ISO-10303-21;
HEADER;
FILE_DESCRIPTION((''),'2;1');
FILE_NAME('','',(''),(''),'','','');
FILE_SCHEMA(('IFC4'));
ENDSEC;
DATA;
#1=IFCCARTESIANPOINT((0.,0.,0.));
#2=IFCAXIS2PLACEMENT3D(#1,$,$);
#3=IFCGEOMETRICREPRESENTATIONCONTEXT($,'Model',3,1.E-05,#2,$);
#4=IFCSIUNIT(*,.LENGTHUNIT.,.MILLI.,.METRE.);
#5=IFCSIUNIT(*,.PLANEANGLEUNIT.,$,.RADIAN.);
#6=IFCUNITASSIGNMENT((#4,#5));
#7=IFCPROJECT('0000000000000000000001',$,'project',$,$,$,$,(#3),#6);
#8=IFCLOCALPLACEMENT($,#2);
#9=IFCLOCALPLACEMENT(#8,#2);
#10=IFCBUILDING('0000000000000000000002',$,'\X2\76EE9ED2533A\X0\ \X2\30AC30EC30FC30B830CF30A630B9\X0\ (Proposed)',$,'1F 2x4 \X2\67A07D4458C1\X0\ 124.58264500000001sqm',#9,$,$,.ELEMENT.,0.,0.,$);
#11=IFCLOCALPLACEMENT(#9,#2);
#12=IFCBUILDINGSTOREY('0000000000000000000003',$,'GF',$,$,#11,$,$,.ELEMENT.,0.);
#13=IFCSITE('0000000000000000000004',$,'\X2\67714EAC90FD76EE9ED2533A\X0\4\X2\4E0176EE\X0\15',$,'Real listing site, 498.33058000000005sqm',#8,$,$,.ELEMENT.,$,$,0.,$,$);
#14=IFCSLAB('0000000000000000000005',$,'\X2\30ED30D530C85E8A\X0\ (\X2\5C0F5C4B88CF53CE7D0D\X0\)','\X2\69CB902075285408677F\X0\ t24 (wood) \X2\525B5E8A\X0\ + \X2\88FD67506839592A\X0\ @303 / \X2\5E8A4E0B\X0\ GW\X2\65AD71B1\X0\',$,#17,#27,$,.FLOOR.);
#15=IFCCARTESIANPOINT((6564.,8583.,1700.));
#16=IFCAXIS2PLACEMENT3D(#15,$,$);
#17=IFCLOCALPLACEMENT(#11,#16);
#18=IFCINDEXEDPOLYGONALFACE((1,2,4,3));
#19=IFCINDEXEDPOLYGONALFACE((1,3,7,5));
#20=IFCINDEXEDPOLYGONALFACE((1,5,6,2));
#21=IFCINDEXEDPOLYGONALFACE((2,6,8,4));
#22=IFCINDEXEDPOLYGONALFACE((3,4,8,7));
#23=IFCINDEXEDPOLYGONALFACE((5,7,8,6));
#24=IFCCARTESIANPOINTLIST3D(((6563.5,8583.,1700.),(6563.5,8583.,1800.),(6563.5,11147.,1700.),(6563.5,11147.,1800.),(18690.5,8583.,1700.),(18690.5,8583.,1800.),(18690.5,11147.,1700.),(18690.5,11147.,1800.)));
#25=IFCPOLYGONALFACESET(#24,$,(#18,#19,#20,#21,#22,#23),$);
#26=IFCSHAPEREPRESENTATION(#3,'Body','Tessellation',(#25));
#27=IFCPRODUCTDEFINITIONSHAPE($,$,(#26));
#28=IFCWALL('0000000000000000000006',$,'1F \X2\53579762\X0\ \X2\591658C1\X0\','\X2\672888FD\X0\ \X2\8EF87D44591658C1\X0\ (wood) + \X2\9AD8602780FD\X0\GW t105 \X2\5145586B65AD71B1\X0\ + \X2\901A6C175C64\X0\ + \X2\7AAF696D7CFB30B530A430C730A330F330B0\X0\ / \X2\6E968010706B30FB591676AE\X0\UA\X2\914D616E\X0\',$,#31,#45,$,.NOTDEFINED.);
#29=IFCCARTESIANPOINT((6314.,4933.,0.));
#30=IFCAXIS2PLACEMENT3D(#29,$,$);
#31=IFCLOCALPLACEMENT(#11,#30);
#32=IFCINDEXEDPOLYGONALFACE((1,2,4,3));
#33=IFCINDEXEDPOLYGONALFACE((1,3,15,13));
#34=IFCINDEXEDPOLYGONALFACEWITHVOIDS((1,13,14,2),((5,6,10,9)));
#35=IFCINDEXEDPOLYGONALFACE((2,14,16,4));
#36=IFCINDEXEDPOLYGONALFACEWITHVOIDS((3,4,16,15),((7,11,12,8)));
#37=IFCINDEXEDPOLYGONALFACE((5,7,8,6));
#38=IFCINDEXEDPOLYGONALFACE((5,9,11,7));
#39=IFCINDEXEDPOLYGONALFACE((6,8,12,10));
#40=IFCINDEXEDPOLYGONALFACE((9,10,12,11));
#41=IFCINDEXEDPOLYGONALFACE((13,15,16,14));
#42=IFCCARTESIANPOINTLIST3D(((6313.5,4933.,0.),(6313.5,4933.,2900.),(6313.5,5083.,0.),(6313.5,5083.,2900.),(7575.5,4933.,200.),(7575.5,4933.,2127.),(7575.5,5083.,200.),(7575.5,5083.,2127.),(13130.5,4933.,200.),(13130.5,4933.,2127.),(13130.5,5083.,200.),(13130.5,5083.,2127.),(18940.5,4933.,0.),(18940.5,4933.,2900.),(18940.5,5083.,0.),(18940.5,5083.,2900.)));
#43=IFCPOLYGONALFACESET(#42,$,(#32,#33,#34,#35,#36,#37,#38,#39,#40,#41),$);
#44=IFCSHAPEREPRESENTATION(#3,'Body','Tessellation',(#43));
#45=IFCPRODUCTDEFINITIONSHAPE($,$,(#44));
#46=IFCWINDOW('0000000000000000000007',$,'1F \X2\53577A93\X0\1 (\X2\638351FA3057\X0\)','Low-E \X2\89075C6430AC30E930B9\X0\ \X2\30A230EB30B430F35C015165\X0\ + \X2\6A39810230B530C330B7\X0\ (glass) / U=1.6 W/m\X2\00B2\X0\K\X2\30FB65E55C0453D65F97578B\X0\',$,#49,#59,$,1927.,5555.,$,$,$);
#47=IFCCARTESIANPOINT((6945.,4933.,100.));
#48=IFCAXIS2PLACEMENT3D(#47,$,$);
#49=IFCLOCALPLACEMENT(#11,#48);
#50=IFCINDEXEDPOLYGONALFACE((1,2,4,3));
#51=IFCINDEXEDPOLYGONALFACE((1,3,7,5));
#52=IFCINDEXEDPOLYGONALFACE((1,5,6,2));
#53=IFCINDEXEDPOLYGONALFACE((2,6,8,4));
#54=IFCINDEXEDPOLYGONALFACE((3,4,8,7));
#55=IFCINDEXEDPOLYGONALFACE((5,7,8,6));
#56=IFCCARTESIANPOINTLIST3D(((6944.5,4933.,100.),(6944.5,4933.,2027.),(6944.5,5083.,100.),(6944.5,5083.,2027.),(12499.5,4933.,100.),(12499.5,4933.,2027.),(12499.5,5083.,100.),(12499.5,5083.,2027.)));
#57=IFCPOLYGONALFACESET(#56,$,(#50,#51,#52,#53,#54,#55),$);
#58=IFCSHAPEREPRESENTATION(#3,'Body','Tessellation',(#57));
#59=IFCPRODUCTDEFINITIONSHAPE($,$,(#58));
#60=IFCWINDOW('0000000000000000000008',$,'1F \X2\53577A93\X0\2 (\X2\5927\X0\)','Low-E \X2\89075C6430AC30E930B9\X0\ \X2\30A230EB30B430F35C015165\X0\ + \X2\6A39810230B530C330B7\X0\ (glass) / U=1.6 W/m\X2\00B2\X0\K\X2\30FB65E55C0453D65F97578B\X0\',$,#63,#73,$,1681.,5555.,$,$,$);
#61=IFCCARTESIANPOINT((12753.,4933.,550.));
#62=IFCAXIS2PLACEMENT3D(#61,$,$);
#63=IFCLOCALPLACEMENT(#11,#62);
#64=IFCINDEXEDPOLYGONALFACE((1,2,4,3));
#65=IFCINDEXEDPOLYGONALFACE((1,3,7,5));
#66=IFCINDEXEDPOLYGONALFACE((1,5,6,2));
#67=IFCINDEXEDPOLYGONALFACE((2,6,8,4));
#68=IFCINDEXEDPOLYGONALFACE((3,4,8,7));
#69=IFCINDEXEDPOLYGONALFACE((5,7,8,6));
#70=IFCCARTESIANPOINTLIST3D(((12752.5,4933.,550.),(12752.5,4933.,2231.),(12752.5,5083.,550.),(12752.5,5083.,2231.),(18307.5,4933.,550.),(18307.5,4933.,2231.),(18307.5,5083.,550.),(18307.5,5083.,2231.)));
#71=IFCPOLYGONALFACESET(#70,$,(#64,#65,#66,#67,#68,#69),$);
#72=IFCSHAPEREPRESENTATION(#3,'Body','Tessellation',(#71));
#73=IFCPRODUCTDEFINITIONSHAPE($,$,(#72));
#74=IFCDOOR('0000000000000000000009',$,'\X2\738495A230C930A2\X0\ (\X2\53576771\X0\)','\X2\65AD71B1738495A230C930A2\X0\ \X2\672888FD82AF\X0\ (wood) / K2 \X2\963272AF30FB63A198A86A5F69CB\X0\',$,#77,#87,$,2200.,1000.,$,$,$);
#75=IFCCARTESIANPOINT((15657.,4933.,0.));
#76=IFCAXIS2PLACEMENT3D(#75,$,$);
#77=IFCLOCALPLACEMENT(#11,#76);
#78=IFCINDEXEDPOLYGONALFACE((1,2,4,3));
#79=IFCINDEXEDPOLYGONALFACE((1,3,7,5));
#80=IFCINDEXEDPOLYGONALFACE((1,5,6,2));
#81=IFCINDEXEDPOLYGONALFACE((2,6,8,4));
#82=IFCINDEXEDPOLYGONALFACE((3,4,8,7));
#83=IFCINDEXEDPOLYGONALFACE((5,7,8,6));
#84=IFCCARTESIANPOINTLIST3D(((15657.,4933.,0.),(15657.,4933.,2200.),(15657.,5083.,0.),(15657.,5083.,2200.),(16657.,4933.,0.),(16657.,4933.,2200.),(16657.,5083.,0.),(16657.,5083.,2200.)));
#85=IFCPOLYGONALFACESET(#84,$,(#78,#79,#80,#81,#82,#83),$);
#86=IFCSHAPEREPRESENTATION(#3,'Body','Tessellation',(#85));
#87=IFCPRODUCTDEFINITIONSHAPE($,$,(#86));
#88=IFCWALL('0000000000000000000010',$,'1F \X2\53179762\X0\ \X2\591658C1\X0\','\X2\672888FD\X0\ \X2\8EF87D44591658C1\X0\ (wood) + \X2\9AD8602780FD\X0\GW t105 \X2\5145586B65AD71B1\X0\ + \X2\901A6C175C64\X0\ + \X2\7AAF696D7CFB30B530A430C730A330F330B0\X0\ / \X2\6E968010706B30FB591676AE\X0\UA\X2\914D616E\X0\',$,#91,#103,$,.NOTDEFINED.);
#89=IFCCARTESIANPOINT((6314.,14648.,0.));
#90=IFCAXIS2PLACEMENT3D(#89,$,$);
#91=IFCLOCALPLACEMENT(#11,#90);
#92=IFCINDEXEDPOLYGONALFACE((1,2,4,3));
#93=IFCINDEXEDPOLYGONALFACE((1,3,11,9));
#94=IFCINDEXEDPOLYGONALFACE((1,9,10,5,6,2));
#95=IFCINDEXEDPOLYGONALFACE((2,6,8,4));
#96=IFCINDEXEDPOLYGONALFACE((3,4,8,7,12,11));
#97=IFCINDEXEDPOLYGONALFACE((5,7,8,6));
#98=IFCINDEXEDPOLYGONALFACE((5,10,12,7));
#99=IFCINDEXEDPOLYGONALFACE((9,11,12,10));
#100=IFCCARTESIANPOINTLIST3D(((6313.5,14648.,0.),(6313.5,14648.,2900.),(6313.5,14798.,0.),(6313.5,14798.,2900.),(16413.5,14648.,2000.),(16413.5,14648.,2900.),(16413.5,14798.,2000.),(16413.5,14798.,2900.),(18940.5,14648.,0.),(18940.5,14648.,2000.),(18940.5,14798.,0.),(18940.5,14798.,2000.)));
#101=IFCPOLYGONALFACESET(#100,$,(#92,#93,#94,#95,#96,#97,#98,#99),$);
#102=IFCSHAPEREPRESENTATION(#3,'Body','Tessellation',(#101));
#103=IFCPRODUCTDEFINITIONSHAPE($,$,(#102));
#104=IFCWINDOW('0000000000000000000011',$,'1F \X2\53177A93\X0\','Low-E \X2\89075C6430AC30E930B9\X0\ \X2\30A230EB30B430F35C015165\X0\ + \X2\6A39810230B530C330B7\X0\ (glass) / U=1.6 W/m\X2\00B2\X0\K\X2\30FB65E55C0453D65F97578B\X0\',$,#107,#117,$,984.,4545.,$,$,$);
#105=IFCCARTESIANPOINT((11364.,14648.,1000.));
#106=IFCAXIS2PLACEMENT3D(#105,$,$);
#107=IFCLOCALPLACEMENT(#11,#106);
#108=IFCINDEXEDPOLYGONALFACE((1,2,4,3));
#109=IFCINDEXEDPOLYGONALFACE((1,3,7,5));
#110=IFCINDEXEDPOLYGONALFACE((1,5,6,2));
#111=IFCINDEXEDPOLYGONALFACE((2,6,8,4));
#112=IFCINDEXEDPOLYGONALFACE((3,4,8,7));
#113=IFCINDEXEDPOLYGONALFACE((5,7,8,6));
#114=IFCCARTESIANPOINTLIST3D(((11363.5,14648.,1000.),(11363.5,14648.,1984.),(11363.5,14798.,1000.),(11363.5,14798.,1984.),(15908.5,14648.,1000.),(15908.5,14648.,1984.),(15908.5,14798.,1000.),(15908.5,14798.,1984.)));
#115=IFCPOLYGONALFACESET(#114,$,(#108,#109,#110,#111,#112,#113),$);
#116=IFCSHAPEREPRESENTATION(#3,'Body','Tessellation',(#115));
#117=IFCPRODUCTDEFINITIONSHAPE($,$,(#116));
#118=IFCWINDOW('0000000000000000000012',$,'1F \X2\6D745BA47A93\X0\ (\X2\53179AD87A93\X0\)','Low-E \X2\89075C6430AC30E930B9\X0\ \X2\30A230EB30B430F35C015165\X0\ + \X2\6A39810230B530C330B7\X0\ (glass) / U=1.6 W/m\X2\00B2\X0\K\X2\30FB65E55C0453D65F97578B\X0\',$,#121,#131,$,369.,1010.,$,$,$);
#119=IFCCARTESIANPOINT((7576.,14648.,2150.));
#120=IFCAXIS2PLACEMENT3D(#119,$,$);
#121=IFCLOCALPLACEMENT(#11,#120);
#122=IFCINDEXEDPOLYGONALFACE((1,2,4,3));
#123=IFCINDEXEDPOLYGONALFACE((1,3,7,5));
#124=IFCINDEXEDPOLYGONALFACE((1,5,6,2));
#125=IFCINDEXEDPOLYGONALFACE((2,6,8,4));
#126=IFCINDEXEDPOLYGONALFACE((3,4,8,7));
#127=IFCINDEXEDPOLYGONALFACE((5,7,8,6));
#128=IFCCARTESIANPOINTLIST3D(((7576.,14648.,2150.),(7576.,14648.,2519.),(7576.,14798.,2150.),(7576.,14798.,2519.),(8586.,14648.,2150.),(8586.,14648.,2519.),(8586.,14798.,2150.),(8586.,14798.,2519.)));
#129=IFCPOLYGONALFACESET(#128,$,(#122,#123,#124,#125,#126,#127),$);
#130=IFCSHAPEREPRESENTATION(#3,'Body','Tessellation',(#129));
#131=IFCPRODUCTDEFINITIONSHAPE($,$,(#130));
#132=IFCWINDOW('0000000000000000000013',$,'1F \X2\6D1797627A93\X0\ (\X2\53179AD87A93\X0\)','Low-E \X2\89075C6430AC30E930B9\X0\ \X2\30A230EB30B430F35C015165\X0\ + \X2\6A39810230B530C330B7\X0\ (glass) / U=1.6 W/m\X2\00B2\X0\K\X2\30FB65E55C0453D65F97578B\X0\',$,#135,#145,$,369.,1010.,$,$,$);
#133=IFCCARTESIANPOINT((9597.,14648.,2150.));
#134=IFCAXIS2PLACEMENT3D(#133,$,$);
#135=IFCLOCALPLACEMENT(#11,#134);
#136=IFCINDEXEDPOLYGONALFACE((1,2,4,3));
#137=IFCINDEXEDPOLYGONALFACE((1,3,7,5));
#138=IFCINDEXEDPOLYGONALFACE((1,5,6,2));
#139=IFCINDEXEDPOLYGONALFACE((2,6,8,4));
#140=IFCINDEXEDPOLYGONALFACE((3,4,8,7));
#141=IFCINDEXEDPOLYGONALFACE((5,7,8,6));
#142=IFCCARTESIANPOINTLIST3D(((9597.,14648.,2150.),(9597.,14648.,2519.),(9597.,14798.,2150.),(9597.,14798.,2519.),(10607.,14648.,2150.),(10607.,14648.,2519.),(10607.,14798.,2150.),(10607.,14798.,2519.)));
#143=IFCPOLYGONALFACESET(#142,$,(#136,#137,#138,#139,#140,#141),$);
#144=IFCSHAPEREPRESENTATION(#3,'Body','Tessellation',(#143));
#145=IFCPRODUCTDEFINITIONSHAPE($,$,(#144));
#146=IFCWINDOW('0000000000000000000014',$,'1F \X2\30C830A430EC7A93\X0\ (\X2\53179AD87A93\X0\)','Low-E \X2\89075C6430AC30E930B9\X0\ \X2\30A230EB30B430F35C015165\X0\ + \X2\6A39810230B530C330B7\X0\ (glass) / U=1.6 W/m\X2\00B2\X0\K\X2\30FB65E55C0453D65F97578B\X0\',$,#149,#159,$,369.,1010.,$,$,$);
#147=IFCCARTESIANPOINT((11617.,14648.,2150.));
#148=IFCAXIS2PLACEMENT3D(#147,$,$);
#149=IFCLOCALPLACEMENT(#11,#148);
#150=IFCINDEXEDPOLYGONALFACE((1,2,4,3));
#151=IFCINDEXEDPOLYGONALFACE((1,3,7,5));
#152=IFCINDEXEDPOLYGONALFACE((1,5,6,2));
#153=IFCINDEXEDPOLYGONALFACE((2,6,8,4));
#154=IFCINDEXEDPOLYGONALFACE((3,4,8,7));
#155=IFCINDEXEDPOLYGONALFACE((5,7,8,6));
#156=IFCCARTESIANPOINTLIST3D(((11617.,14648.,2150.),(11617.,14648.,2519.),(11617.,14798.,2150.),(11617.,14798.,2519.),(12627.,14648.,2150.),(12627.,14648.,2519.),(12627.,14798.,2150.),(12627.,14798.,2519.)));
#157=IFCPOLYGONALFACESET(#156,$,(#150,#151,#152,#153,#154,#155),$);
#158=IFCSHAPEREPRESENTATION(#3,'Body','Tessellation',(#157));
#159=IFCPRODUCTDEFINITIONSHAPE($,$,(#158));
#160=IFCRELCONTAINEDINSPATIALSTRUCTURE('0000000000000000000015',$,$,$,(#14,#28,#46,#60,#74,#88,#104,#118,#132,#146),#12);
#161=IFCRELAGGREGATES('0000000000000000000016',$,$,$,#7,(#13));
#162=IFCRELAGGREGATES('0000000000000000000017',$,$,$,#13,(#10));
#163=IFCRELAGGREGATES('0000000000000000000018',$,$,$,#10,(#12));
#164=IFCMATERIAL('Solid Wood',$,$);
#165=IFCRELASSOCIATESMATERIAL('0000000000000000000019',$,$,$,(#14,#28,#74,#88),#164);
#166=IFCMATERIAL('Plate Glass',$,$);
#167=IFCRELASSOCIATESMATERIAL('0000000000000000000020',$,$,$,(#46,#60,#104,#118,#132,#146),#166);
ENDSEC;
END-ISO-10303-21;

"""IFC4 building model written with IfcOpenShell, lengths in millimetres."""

from ifc_helpers import new_model, si_unit, frame, frame_2d, origin, place, context, project, spatial, rectangle, extrude, material, element, fill, save


model = new_model("IFC4")

# Units and contexts
model_context = context("Model", 3, precision=1e-05, world=origin())
ifc_project = project(units=[si_unit("LENGTHUNIT", "METRE", prefix="MILLI"), si_unit("PLANEANGLEUNIT", "RADIAN")], contexts=[model_context])

# Site, building, storey
site_placement = place(None, origin())
site = spatial("IfcSite", under=ifc_project, at=site_placement, Name="東京都目黒区4丁目15", ObjectType="Real listing site, 498.33058000000005sqm", CompositionType="ELEMENT", RefElevation=0.0)
building_placement = place(site_placement, origin())
building = spatial("IfcBuilding", under=site, at=building_placement, Name="目黒区 ガレージハウス (Proposed)", ObjectType="1F 2x4 枠組壁 124.58264500000001sqm", CompositionType="ELEMENT", ElevationOfRefHeight=0.0, ElevationOfTerrain=0.0)
storey_placement = place(building_placement, origin())
storey = spatial("IfcBuildingStorey", under=building, at=storey_placement, Name="GF", CompositionType="ELEMENT", Elevation=0.0)

# Slab
ifc_material_1 = material(Name="Solid Wood")
slab_1_placement = place(storey_placement, frame((6564.0, 8583.0, 1700.0)))
element("IfcSlab", 1, at=slab_1_placement, inside=storey, material=ifc_material_1, Name="ロフト床 (小屋裏収納)", Description="構造用合板 t24 (wood) 剛床 + 製材根太 @303 / 床下 GW断熱", PredefinedType="FLOOR", context=model_context, shape_type="SweptSolid", body=[
    extrude(rectangle(XDim=12127.0, YDim=2564.0, at=frame_2d((6063.0, 1282.0))), frame((6564.0, 8583.0, 1700.0)), (0.0, 0.0, 1.0), 100.0),
])

# Wall, openings, windows, door
wall_1_placement = place(storey_placement, frame((6314.0, 4933.0, 0.0)))
wall_1 = element("IfcWall", 2, at=wall_1_placement, inside=storey, material=ifc_material_1, Name="1F 南面 外壁", Description="木製 軸組外壁 (wood) + 高性能GW t105 充填断熱 + 通気層 + 窯業系サイディング / 準耐火・外皮UA配慮", PredefinedType="NOTDEFINED", context=model_context, shape_type="SweptSolid", body=[
    extrude(rectangle(XDim=12627.0, YDim=150.0, at=frame_2d((6313.0, 75.0))), frame((6314.0, 4933.0, 0.0)), (0.0, 0.0, 1.0), 2900.0),
])
opening_1_placement = place(storey_placement, frame((6945.0, 4933.0, 100.0)))
opening_1 = element("IfcOpeningElement", 3, at=opening_1_placement, cuts=wall_1, PredefinedType="NOTDEFINED", context=model_context, shape_type="SweptSolid", body=[
    extrude(rectangle(XDim=5555.0, YDim=150.0, at=frame_2d((2777.0, 75.0))), frame((6945.0, 4933.0, 100.0)), (0.0, 0.0, 1.0), 1927.0),
])
opening_2_placement = place(storey_placement, frame((12753.0, 4933.0, 550.0)))
opening_2 = element("IfcOpeningElement", 4, at=opening_2_placement, cuts=wall_1, PredefinedType="NOTDEFINED", context=model_context, shape_type="SweptSolid", body=[
    extrude(rectangle(XDim=5555.0, YDim=150.0, at=frame_2d((2777.0, 75.0))), frame((12753.0, 4933.0, 550.0)), (0.0, 0.0, 1.0), 1681.0),
])
opening_3_placement = place(storey_placement, frame((15657.0, 4933.0, 0.0)))
opening_3 = element("IfcOpeningElement", 5, at=opening_3_placement, cuts=wall_1, PredefinedType="NOTDEFINED", context=model_context, shape_type="SweptSolid", body=[
    extrude(rectangle(XDim=1000.0, YDim=150.0, at=frame_2d((500.0, 75.0))), frame((15657.0, 4933.0, 0.0)), (0.0, 0.0, 1.0), 2200.0),
])
ifc_material_2 = material(Name="Plate Glass")
window_1_placement = place(storey_placement, frame((6945.0, 4933.0, 100.0)))
window_1 = element("IfcWindow", 6, at=window_1_placement, inside=storey, material=ifc_material_2, Name="1F 南窓1 (掃出し)", Description="Low-E 複層ガラス アルゴン封入 + 樹脂サッシ (glass) / U=1.6 W/m²K・日射取得型", OverallHeight=1927.0, OverallWidth=5555.0, context=model_context, shape_type="SweptSolid", body=[
    extrude(rectangle(XDim=5555.0, YDim=150.0, at=frame_2d((2777.0, 75.0))), frame((6945.0, 4933.0, 100.0)), (0.0, 0.0, 1.0), 1927.0),
])
fill(opening_1, window_1)
window_2_placement = place(storey_placement, frame((12753.0, 4933.0, 550.0)))
window_2 = element("IfcWindow", 7, at=window_2_placement, inside=storey, material=ifc_material_2, Name="1F 南窓2 (大)", Description="Low-E 複層ガラス アルゴン封入 + 樹脂サッシ (glass) / U=1.6 W/m²K・日射取得型", OverallHeight=1681.0, OverallWidth=5555.0, context=model_context, shape_type="SweptSolid", body=[
    extrude(rectangle(XDim=5555.0, YDim=150.0, at=frame_2d((2777.0, 75.0))), frame((12753.0, 4933.0, 550.0)), (0.0, 0.0, 1.0), 1681.0),
])
fill(opening_2, window_2)
door_1_placement = place(storey_placement, frame((15657.0, 4933.0, 0.0)))
door_1 = element("IfcDoor", 8, at=door_1_placement, inside=storey, material=ifc_material_1, Name="玄関ドア (南東)", Description="断熱玄関ドア 木製芯 (wood) / K2 防犯・採風機構", OverallHeight=2200.0, OverallWidth=1000.0, context=model_context, shape_type="SweptSolid", body=[
    extrude(rectangle(XDim=1000.0, YDim=150.0, at=frame_2d((500.0, 75.0))), frame((15657.0, 4933.0, 0.0)), (0.0, 0.0, 1.0), 2200.0),
])
fill(opening_3, door_1)

# Wall, openings, windows
wall_2_placement = place(storey_placement, frame((6314.0, 14648.0, 0.0)))
wall_2 = element("IfcWall", 9, at=wall_2_placement, inside=storey, material=ifc_material_1, Name="1F 北面 外壁", Description="木製 軸組外壁 (wood) + 高性能GW t105 充填断熱 + 通気層 + 窯業系サイディング / 準耐火・外皮UA配慮", PredefinedType="NOTDEFINED", context=model_context, shape_type="SweptSolid", body=[
    extrude(rectangle(XDim=12627.0, YDim=150.0, at=frame_2d((6313.0, 75.0))), frame((6314.0, 14648.0, 0.0)), (0.0, 0.0, 1.0), 2900.0),
])
opening_4_placement = place(storey_placement, frame((11364.0, 14648.0, 1000.0)))
opening_4 = element("IfcOpeningElement", 10, at=opening_4_placement, cuts=wall_2, PredefinedType="NOTDEFINED", context=model_context, shape_type="SweptSolid", body=[
    extrude(rectangle(XDim=4545.0, YDim=150.0, at=frame_2d((2272.0, 75.0))), frame((11364.0, 14648.0, 1000.0)), (0.0, 0.0, 1.0), 984.0),
])
opening_5_placement = place(storey_placement, frame((7576.0, 14648.0, 2150.0)))
opening_5 = element("IfcOpeningElement", 11, at=opening_5_placement, cuts=wall_2, PredefinedType="NOTDEFINED", context=model_context, shape_type="SweptSolid", body=[
    extrude(rectangle(XDim=1010.0, YDim=150.0, at=frame_2d((505.0, 75.0))), frame((7576.0, 14648.0, 2150.0)), (0.0, 0.0, 1.0), 369.0),
])
opening_6_placement = place(storey_placement, frame((9597.0, 14648.0, 2150.0)))
opening_6 = element("IfcOpeningElement", 12, at=opening_6_placement, cuts=wall_2, PredefinedType="NOTDEFINED", context=model_context, shape_type="SweptSolid", body=[
    extrude(rectangle(XDim=1010.0, YDim=150.0, at=frame_2d((505.0, 75.0))), frame((9597.0, 14648.0, 2150.0)), (0.0, 0.0, 1.0), 369.0),
])
opening_7_placement = place(storey_placement, frame((11617.0, 14648.0, 2150.0)))
opening_7 = element("IfcOpeningElement", 13, at=opening_7_placement, cuts=wall_2, PredefinedType="NOTDEFINED", context=model_context, shape_type="SweptSolid", body=[
    extrude(rectangle(XDim=1010.0, YDim=150.0, at=frame_2d((505.0, 75.0))), frame((11617.0, 14648.0, 2150.0)), (0.0, 0.0, 1.0), 369.0),
])
window_3_placement = place(storey_placement, frame((11364.0, 14648.0, 1000.0)))
window_3 = element("IfcWindow", 14, at=window_3_placement, inside=storey, material=ifc_material_2, Name="1F 北窓", Description="Low-E 複層ガラス アルゴン封入 + 樹脂サッシ (glass) / U=1.6 W/m²K・日射取得型", OverallHeight=984.0, OverallWidth=4545.0, context=model_context, shape_type="SweptSolid", body=[
    extrude(rectangle(XDim=4545.0, YDim=150.0, at=frame_2d((2272.0, 75.0))), frame((11364.0, 14648.0, 1000.0)), (0.0, 0.0, 1.0), 984.0),
])
fill(opening_4, window_3)
window_4_placement = place(storey_placement, frame((7576.0, 14648.0, 2150.0)))
window_4 = element("IfcWindow", 15, at=window_4_placement, inside=storey, material=ifc_material_2, Name="1F 浴室窓 (北高窓)", Description="Low-E 複層ガラス アルゴン封入 + 樹脂サッシ (glass) / U=1.6 W/m²K・日射取得型", OverallHeight=369.0, OverallWidth=1010.0, context=model_context, shape_type="SweptSolid", body=[
    extrude(rectangle(XDim=1010.0, YDim=150.0, at=frame_2d((505.0, 75.0))), frame((7576.0, 14648.0, 2150.0)), (0.0, 0.0, 1.0), 369.0),
])
fill(opening_5, window_4)
window_5_placement = place(storey_placement, frame((9597.0, 14648.0, 2150.0)))
window_5 = element("IfcWindow", 16, at=window_5_placement, inside=storey, material=ifc_material_2, Name="1F 洗面窓 (北高窓)", Description="Low-E 複層ガラス アルゴン封入 + 樹脂サッシ (glass) / U=1.6 W/m²K・日射取得型", OverallHeight=369.0, OverallWidth=1010.0, context=model_context, shape_type="SweptSolid", body=[
    extrude(rectangle(XDim=1010.0, YDim=150.0, at=frame_2d((505.0, 75.0))), frame((9597.0, 14648.0, 2150.0)), (0.0, 0.0, 1.0), 369.0),
])
fill(opening_6, window_5)
window_6_placement = place(storey_placement, frame((11617.0, 14648.0, 2150.0)))
window_6 = element("IfcWindow", 17, at=window_6_placement, inside=storey, material=ifc_material_2, Name="1F トイレ窓 (北高窓)", Description="Low-E 複層ガラス アルゴン封入 + 樹脂サッシ (glass) / U=1.6 W/m²K・日射取得型", OverallHeight=369.0, OverallWidth=1010.0, context=model_context, shape_type="SweptSolid", body=[
    extrude(rectangle(XDim=1010.0, YDim=150.0, at=frame_2d((505.0, 75.0))), frame((11617.0, 14648.0, 2150.0)), (0.0, 0.0, 1.0), 369.0),
])
fill(opening_7, window_6)

save(model, "model.ifc")
